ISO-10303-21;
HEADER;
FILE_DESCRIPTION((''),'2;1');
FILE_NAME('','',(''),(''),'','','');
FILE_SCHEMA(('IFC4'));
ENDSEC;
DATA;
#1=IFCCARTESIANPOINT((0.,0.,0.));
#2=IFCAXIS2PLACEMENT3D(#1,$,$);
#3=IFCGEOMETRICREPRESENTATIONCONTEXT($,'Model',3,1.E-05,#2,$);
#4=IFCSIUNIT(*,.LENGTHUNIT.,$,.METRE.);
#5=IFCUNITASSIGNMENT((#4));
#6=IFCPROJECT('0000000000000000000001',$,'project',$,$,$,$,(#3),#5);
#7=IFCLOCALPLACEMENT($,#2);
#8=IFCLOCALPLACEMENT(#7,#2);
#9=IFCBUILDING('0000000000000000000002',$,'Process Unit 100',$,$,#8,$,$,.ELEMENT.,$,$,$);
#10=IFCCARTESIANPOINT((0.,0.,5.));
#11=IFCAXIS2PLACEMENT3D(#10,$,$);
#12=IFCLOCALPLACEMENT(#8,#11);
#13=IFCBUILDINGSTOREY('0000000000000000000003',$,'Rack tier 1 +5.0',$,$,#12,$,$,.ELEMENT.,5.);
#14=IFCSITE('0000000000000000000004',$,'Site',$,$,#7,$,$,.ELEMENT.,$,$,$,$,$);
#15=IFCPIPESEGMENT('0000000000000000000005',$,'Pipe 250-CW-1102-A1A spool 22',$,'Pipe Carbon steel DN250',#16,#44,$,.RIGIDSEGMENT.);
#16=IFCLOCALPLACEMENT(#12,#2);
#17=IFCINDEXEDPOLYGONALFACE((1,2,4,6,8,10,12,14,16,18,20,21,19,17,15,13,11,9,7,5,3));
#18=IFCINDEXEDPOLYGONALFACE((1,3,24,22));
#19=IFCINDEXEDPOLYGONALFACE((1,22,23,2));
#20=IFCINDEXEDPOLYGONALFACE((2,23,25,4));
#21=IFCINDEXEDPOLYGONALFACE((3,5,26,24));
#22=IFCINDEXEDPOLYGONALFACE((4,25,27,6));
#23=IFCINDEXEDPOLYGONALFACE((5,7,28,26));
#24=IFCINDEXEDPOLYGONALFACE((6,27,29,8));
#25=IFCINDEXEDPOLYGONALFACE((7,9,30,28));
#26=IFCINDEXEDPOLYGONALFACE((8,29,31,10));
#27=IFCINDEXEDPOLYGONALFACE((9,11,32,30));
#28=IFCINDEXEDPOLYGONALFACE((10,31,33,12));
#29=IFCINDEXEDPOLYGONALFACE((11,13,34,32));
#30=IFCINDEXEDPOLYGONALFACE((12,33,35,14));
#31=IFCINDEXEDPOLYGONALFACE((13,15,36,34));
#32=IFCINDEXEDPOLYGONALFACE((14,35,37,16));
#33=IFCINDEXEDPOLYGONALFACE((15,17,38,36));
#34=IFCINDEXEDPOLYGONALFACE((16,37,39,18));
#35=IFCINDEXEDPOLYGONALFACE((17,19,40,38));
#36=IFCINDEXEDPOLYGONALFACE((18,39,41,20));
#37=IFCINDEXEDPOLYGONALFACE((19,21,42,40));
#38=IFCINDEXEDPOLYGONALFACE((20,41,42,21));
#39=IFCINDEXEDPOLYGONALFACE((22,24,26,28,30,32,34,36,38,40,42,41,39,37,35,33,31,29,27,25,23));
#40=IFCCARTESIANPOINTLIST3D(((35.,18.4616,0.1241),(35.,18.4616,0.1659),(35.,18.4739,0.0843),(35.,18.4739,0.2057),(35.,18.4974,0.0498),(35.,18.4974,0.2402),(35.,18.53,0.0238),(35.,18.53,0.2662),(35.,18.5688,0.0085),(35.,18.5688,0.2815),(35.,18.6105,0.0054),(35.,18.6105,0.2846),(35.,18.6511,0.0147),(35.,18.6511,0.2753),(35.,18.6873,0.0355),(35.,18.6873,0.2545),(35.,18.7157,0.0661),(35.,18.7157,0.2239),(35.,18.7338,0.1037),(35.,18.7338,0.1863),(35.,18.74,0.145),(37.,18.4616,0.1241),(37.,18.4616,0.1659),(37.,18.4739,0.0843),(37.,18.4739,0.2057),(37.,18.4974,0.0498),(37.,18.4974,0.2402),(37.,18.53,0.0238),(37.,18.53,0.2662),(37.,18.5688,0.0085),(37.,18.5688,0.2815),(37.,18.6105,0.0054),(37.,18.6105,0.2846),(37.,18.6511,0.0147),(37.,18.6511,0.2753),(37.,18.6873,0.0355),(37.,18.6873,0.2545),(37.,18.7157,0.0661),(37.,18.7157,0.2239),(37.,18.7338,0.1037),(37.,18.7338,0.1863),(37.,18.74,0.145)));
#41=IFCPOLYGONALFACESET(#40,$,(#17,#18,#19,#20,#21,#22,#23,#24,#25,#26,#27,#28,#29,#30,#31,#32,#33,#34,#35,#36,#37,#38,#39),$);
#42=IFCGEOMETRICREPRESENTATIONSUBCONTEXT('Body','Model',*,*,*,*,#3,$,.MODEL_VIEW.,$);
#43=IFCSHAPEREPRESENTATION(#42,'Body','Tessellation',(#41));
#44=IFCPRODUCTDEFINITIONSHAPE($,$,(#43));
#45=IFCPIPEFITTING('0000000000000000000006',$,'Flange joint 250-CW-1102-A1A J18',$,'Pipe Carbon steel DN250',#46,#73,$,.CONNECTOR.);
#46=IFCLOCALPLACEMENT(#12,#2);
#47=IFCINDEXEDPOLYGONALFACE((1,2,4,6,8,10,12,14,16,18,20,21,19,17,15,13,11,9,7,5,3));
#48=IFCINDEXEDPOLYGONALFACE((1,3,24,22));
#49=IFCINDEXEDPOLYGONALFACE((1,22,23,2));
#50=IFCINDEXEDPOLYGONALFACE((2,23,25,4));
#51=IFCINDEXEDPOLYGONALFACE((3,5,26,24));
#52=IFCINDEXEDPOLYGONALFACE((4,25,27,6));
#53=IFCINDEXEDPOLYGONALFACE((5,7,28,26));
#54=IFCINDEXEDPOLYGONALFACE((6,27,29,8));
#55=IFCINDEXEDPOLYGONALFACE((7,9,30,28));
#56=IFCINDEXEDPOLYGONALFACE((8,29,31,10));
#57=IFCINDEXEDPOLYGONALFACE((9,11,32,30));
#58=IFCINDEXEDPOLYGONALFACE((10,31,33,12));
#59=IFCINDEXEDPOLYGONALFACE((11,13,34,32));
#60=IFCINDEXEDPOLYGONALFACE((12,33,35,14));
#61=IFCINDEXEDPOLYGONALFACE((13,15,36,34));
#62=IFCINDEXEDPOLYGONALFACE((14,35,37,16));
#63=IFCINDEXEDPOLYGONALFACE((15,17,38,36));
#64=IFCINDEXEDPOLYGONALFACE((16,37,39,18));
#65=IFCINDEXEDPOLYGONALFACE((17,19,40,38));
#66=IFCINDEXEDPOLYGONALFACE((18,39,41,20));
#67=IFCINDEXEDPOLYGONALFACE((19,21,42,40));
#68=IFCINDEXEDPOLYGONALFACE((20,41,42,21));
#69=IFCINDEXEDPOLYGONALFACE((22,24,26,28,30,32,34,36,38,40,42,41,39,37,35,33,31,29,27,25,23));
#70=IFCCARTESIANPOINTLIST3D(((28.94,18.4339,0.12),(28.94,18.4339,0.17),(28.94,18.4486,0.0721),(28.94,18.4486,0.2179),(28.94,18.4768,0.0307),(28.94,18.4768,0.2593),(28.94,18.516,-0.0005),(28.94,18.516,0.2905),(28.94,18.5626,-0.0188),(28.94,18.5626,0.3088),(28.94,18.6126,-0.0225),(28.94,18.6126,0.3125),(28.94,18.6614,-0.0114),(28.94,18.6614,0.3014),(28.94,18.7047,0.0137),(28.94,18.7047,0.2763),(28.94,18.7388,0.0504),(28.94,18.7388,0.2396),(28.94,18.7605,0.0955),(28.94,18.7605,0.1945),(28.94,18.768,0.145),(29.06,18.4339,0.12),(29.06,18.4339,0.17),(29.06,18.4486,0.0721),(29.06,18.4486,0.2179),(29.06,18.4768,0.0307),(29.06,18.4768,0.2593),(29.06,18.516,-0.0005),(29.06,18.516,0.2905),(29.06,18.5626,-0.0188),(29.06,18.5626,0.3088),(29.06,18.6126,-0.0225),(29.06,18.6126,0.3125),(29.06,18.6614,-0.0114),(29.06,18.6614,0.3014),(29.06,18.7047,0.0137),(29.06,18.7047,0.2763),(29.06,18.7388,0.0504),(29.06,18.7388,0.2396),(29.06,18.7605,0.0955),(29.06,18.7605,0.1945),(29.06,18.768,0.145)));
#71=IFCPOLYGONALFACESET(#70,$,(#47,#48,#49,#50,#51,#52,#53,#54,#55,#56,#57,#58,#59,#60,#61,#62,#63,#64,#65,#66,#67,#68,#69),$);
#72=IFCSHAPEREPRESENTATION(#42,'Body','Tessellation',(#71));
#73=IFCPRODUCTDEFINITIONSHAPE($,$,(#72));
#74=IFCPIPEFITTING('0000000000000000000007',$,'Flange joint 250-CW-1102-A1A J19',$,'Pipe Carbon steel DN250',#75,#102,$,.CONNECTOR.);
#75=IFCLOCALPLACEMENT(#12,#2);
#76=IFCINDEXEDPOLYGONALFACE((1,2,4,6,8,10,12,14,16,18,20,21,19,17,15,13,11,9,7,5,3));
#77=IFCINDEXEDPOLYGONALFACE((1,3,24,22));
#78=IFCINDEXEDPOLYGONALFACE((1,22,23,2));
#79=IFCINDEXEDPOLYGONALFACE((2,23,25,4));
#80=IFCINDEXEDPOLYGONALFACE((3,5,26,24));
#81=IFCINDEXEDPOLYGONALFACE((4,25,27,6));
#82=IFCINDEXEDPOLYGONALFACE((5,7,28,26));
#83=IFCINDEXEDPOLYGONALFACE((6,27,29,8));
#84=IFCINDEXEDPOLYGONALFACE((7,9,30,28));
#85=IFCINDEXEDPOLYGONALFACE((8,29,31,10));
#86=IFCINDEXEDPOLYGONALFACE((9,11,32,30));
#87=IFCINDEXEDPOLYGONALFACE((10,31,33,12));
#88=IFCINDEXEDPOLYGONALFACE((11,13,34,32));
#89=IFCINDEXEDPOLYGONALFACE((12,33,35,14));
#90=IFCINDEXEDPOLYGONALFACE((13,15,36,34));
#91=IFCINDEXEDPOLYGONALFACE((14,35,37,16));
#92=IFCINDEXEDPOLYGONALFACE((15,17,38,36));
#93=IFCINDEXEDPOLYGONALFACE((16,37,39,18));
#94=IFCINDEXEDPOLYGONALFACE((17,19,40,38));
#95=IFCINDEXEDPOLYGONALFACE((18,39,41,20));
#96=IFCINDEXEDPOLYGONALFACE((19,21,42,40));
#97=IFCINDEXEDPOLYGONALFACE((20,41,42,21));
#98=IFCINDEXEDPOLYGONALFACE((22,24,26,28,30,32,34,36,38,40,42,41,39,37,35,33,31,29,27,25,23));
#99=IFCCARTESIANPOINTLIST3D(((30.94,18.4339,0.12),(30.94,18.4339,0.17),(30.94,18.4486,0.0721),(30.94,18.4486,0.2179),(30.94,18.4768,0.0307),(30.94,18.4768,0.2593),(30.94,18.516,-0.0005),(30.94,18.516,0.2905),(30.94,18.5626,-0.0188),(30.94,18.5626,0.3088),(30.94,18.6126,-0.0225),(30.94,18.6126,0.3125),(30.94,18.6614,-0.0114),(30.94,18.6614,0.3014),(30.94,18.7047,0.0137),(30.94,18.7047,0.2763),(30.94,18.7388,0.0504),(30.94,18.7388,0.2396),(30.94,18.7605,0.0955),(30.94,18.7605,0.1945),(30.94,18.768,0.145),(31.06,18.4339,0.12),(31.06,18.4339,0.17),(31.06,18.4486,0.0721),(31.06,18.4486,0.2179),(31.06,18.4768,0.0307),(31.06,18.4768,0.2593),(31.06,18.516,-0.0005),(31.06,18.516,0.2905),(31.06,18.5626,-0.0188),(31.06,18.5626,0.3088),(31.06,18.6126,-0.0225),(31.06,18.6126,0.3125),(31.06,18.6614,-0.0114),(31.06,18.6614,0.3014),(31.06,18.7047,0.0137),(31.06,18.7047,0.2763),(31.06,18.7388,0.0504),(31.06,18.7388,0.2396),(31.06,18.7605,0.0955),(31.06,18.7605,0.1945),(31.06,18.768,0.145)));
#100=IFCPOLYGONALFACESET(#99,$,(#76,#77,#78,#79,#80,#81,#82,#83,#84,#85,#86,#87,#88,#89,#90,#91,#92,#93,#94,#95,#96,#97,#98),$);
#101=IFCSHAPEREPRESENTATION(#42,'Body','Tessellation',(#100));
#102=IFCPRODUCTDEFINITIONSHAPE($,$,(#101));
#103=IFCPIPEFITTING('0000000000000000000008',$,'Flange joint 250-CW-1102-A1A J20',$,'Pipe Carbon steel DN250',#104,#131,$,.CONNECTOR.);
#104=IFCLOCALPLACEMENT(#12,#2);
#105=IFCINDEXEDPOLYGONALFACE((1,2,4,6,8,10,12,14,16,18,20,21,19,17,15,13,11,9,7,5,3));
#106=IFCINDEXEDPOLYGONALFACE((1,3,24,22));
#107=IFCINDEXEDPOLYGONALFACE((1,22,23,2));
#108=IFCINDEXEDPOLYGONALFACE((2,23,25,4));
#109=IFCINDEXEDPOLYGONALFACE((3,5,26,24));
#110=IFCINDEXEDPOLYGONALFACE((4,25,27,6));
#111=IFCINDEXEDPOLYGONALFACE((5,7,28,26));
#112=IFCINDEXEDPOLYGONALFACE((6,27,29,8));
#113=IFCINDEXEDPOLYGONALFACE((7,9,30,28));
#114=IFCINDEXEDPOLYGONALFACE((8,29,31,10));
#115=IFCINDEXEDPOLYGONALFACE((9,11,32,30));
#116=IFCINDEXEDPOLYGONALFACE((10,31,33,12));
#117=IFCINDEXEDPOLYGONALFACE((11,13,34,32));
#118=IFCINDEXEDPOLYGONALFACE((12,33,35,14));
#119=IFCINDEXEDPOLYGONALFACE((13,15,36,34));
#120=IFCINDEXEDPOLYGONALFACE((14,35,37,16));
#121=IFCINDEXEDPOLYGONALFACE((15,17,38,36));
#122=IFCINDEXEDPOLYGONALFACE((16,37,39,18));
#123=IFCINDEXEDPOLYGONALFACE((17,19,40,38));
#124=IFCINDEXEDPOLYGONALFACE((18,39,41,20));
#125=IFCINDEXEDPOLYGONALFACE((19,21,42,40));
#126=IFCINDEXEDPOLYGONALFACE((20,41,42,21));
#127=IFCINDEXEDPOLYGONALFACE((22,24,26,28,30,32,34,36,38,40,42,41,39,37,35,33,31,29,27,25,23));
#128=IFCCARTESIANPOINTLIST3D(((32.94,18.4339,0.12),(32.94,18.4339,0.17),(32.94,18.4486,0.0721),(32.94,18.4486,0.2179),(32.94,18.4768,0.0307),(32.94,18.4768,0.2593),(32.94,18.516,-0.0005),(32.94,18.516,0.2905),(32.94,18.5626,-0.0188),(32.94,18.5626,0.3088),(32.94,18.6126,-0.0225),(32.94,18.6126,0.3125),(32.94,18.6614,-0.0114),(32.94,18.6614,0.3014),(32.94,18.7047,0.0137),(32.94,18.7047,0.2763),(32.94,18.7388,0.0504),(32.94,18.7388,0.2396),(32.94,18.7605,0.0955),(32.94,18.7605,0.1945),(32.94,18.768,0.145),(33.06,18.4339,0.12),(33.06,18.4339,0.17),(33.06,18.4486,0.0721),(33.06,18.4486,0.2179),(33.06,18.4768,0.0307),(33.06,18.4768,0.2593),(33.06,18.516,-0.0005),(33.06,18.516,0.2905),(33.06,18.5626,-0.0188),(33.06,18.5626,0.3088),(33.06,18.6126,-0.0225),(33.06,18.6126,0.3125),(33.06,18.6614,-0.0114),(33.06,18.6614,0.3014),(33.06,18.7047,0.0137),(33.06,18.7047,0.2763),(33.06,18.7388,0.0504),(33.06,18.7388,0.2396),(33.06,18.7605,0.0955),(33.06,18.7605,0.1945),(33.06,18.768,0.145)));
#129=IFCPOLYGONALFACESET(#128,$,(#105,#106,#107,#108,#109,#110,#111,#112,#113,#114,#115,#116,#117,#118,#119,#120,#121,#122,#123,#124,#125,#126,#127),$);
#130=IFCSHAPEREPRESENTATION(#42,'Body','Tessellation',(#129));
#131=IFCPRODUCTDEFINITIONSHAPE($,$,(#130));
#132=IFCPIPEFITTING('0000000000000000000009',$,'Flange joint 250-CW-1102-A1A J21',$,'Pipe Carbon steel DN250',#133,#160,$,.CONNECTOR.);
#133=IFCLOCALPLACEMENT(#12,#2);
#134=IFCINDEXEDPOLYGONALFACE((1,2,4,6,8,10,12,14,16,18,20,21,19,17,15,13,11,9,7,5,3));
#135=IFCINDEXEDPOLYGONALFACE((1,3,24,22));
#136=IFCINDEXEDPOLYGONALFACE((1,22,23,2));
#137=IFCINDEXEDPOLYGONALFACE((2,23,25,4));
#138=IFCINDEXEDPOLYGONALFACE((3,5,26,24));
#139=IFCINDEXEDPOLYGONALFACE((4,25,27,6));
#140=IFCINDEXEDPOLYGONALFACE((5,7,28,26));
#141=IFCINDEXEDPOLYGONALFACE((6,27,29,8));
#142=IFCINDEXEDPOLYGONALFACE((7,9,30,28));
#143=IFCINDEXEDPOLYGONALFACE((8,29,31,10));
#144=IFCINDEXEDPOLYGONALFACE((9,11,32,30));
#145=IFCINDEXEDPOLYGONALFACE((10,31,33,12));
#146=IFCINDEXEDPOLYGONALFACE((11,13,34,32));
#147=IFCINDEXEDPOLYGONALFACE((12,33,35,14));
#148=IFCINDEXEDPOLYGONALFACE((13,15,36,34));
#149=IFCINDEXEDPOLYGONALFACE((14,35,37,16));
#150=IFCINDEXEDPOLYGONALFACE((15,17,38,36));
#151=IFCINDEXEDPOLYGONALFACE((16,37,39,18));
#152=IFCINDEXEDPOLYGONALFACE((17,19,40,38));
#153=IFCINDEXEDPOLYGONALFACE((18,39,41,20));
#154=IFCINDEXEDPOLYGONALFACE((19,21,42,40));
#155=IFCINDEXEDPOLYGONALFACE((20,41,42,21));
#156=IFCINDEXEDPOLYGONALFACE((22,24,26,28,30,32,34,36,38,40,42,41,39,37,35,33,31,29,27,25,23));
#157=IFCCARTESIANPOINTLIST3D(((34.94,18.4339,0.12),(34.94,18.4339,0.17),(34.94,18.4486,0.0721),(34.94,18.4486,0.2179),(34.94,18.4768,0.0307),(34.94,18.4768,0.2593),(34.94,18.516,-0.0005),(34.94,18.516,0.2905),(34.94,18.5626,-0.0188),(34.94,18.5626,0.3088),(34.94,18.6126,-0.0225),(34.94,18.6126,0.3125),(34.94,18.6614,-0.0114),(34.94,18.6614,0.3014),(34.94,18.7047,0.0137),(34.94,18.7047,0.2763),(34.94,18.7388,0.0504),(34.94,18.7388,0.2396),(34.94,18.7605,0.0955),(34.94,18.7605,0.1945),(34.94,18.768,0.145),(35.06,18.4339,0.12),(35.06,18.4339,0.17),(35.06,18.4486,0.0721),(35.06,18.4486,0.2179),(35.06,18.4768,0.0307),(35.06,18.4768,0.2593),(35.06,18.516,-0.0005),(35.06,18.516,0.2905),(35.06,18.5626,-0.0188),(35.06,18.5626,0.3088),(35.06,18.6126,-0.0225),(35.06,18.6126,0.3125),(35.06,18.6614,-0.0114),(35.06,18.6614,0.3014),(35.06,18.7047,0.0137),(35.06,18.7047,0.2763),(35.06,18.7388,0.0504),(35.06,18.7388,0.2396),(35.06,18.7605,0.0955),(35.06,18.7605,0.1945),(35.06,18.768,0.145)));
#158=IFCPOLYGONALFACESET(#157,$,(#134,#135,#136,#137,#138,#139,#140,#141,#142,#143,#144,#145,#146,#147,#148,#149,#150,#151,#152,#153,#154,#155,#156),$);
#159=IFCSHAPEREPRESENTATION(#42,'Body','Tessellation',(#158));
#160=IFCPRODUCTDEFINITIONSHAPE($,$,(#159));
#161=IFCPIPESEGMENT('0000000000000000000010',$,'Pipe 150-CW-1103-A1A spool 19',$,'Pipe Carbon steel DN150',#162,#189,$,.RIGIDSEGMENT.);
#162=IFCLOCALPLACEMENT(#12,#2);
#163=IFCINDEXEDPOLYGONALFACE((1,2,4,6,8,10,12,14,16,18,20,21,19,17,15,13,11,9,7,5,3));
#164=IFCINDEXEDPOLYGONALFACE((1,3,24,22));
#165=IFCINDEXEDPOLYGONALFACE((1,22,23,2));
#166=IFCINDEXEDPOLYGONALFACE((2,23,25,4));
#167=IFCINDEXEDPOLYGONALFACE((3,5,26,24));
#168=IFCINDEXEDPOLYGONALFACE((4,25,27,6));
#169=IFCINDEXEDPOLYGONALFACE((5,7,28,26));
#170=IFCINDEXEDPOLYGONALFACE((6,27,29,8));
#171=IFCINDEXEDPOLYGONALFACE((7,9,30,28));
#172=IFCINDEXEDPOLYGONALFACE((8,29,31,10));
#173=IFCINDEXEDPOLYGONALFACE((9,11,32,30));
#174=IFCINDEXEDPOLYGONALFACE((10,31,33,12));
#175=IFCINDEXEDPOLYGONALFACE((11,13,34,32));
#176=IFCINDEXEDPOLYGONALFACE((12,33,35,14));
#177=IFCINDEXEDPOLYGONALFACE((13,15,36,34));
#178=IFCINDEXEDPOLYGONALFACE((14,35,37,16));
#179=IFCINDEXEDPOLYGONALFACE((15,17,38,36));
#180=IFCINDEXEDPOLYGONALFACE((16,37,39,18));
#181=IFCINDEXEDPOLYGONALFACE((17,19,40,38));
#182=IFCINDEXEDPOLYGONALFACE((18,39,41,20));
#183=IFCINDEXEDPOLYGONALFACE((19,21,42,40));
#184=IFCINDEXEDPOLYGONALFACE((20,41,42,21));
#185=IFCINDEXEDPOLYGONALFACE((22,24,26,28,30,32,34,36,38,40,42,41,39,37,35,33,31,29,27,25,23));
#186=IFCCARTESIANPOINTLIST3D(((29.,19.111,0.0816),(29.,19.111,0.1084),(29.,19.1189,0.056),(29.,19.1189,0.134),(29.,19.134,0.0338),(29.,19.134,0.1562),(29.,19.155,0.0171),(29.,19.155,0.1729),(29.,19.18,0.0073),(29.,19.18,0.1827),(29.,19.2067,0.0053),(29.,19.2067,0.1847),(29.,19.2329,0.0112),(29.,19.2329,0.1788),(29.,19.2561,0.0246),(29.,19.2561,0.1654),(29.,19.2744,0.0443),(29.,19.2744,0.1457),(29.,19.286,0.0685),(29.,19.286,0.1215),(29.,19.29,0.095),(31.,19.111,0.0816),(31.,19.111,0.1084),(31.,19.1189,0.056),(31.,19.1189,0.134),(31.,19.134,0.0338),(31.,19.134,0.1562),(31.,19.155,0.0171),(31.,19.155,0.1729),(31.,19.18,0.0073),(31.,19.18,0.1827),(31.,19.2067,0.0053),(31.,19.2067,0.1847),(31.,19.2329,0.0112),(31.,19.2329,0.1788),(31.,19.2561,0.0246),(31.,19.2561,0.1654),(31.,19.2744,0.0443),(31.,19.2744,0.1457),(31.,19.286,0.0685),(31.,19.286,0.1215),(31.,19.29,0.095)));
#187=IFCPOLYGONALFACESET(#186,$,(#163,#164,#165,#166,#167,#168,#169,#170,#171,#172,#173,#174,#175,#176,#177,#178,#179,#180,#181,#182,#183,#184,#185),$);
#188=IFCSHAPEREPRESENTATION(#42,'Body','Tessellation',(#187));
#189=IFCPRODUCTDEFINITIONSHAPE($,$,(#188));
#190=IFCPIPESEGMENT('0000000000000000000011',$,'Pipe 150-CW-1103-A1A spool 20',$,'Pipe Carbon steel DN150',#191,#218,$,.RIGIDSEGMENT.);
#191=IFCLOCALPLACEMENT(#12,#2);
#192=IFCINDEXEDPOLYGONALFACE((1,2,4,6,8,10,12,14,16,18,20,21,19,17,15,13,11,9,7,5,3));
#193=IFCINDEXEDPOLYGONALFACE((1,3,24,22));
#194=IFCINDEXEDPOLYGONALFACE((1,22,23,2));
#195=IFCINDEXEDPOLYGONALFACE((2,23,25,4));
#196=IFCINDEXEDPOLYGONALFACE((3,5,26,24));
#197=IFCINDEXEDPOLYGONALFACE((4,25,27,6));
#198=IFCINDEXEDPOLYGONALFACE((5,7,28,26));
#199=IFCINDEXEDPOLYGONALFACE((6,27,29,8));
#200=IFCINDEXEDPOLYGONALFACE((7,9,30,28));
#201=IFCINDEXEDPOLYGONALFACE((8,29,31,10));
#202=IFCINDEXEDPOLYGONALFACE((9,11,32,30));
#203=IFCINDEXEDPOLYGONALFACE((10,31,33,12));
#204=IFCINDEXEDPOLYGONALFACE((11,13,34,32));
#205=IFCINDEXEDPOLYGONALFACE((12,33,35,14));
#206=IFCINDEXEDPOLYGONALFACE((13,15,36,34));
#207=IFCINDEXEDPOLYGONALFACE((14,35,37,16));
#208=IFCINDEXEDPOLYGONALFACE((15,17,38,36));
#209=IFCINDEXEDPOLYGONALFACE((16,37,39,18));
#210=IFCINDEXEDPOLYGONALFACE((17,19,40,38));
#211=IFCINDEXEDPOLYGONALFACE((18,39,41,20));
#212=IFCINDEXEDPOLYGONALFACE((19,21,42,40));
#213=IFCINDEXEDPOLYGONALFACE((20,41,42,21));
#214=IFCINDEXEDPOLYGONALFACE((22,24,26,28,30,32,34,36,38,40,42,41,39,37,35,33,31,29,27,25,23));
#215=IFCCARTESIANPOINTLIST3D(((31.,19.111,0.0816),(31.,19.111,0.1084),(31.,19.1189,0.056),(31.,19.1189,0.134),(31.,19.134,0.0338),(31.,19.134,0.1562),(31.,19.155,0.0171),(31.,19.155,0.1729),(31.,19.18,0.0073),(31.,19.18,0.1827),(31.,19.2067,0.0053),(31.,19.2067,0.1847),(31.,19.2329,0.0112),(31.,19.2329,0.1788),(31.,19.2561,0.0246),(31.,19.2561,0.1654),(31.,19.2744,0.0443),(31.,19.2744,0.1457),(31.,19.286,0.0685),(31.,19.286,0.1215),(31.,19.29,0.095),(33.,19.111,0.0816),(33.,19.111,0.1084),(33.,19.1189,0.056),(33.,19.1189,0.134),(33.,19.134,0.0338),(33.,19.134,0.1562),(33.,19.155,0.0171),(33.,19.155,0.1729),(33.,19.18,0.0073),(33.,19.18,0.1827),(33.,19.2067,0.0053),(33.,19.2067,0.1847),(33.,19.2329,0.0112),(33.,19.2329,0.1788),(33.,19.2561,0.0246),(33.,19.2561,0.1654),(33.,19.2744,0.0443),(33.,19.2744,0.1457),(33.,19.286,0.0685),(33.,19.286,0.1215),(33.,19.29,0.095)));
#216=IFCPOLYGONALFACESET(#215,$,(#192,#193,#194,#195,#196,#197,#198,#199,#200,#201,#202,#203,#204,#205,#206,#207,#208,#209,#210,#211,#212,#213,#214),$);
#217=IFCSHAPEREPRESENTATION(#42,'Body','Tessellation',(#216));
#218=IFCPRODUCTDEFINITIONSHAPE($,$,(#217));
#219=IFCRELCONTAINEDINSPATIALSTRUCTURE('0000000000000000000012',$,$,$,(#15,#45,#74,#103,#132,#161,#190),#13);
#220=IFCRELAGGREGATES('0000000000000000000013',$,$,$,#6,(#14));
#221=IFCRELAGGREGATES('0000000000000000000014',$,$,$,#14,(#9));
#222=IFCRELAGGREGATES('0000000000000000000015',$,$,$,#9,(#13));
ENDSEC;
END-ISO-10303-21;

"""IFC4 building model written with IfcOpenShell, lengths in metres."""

from ifc_helpers import new_model, si_unit, frame, origin, place, context, subcontext, project, spatial, circle, extrude, element, save


model = new_model("IFC4")

# Units and contexts
model_context = context("Model", 3, precision=1e-05, world=origin())
body_context = subcontext(model_context, "Body", "Model", "MODEL_VIEW")
ifc_project = project(units=[si_unit("LENGTHUNIT", "METRE")], contexts=[model_context])

# Site, building, storey
site_placement = place(None, origin())
site = spatial("IfcSite", under=ifc_project, at=site_placement, Name="Site", CompositionType="ELEMENT")
building_placement = place(site_placement, origin())
building = spatial("IfcBuilding", under=site, at=building_placement, Name="Process Unit 100", CompositionType="ELEMENT")
storey_placement = place(building_placement, frame((0.0, 0.0, 5.0)))
storey = spatial("IfcBuildingStorey", under=building, at=storey_placement, Name="Rack tier 1 +5.0", CompositionType="ELEMENT", Elevation=5.0)

# Pipe segment
for number, where, z_axis, x_axis, name in (
    (1, (35.0, 18.6, 0.145), (1.0, 0.0, 0.0), (0.0, 1.0, 0.0), "Pipe 250-CW-1102-A1A spool 22"),
):
    element("IfcPipeSegment", number, at=place(storey_placement, frame(where, z_axis=z_axis, x_axis=x_axis)), inside=storey, Name=name, ObjectType="Pipe Carbon steel DN250", PredefinedType="RIGIDSEGMENT", context=body_context, shape_type="SweptSolid", body=[
        extrude(circle(Radius=0.14), origin(), (0.0, 0.0, 1.0), 2.0),
    ])

# Pipe fittings
for number, where, z_axis, x_axis, name in (
    (2, (28.94, 18.6, 0.145), (1.0, 0.0, 0.0), (0.0, 1.0, 0.0), "Flange joint 250-CW-1102-A1A J18"),
    (3, (30.94, 18.6, 0.145), (1.0, 0.0, 0.0), (0.0, 1.0, 0.0), "Flange joint 250-CW-1102-A1A J19"),
    (4, (32.94, 18.6, 0.145), (1.0, 0.0, 0.0), (0.0, 1.0, 0.0), "Flange joint 250-CW-1102-A1A J20"),
    (5, (34.94, 18.6, 0.145), (1.0, 0.0, 0.0), (0.0, 1.0, 0.0), "Flange joint 250-CW-1102-A1A J21"),
):
    element("IfcPipeFitting", number, at=place(storey_placement, frame(where, z_axis=z_axis, x_axis=x_axis)), inside=storey, Name=name, ObjectType="Pipe Carbon steel DN250", PredefinedType="CONNECTOR", context=body_context, shape_type="SweptSolid", body=[
        extrude(circle(Radius=0.168), origin(), (0.0, 0.0, 1.0), 0.12),
    ])

# Pipe segments
for number, where, z_axis, x_axis, name in (
    (6, (29.0, 19.2, 0.095), (1.0, 0.0, 0.0), (0.0, 1.0, 0.0), "Pipe 150-CW-1103-A1A spool 19"),
    (7, (31.0, 19.2, 0.095), (1.0, 0.0, 0.0), (0.0, 1.0, 0.0), "Pipe 150-CW-1103-A1A spool 20"),
):
    element("IfcPipeSegment", number, at=place(storey_placement, frame(where, z_axis=z_axis, x_axis=x_axis)), inside=storey, Name=name, ObjectType="Pipe Carbon steel DN150", PredefinedType="RIGIDSEGMENT", context=body_context, shape_type="SweptSolid", body=[
        extrude(circle(Radius=0.09), origin(), (0.0, 0.0, 1.0), 2.0),
    ])

save(model, "model.ifc")
